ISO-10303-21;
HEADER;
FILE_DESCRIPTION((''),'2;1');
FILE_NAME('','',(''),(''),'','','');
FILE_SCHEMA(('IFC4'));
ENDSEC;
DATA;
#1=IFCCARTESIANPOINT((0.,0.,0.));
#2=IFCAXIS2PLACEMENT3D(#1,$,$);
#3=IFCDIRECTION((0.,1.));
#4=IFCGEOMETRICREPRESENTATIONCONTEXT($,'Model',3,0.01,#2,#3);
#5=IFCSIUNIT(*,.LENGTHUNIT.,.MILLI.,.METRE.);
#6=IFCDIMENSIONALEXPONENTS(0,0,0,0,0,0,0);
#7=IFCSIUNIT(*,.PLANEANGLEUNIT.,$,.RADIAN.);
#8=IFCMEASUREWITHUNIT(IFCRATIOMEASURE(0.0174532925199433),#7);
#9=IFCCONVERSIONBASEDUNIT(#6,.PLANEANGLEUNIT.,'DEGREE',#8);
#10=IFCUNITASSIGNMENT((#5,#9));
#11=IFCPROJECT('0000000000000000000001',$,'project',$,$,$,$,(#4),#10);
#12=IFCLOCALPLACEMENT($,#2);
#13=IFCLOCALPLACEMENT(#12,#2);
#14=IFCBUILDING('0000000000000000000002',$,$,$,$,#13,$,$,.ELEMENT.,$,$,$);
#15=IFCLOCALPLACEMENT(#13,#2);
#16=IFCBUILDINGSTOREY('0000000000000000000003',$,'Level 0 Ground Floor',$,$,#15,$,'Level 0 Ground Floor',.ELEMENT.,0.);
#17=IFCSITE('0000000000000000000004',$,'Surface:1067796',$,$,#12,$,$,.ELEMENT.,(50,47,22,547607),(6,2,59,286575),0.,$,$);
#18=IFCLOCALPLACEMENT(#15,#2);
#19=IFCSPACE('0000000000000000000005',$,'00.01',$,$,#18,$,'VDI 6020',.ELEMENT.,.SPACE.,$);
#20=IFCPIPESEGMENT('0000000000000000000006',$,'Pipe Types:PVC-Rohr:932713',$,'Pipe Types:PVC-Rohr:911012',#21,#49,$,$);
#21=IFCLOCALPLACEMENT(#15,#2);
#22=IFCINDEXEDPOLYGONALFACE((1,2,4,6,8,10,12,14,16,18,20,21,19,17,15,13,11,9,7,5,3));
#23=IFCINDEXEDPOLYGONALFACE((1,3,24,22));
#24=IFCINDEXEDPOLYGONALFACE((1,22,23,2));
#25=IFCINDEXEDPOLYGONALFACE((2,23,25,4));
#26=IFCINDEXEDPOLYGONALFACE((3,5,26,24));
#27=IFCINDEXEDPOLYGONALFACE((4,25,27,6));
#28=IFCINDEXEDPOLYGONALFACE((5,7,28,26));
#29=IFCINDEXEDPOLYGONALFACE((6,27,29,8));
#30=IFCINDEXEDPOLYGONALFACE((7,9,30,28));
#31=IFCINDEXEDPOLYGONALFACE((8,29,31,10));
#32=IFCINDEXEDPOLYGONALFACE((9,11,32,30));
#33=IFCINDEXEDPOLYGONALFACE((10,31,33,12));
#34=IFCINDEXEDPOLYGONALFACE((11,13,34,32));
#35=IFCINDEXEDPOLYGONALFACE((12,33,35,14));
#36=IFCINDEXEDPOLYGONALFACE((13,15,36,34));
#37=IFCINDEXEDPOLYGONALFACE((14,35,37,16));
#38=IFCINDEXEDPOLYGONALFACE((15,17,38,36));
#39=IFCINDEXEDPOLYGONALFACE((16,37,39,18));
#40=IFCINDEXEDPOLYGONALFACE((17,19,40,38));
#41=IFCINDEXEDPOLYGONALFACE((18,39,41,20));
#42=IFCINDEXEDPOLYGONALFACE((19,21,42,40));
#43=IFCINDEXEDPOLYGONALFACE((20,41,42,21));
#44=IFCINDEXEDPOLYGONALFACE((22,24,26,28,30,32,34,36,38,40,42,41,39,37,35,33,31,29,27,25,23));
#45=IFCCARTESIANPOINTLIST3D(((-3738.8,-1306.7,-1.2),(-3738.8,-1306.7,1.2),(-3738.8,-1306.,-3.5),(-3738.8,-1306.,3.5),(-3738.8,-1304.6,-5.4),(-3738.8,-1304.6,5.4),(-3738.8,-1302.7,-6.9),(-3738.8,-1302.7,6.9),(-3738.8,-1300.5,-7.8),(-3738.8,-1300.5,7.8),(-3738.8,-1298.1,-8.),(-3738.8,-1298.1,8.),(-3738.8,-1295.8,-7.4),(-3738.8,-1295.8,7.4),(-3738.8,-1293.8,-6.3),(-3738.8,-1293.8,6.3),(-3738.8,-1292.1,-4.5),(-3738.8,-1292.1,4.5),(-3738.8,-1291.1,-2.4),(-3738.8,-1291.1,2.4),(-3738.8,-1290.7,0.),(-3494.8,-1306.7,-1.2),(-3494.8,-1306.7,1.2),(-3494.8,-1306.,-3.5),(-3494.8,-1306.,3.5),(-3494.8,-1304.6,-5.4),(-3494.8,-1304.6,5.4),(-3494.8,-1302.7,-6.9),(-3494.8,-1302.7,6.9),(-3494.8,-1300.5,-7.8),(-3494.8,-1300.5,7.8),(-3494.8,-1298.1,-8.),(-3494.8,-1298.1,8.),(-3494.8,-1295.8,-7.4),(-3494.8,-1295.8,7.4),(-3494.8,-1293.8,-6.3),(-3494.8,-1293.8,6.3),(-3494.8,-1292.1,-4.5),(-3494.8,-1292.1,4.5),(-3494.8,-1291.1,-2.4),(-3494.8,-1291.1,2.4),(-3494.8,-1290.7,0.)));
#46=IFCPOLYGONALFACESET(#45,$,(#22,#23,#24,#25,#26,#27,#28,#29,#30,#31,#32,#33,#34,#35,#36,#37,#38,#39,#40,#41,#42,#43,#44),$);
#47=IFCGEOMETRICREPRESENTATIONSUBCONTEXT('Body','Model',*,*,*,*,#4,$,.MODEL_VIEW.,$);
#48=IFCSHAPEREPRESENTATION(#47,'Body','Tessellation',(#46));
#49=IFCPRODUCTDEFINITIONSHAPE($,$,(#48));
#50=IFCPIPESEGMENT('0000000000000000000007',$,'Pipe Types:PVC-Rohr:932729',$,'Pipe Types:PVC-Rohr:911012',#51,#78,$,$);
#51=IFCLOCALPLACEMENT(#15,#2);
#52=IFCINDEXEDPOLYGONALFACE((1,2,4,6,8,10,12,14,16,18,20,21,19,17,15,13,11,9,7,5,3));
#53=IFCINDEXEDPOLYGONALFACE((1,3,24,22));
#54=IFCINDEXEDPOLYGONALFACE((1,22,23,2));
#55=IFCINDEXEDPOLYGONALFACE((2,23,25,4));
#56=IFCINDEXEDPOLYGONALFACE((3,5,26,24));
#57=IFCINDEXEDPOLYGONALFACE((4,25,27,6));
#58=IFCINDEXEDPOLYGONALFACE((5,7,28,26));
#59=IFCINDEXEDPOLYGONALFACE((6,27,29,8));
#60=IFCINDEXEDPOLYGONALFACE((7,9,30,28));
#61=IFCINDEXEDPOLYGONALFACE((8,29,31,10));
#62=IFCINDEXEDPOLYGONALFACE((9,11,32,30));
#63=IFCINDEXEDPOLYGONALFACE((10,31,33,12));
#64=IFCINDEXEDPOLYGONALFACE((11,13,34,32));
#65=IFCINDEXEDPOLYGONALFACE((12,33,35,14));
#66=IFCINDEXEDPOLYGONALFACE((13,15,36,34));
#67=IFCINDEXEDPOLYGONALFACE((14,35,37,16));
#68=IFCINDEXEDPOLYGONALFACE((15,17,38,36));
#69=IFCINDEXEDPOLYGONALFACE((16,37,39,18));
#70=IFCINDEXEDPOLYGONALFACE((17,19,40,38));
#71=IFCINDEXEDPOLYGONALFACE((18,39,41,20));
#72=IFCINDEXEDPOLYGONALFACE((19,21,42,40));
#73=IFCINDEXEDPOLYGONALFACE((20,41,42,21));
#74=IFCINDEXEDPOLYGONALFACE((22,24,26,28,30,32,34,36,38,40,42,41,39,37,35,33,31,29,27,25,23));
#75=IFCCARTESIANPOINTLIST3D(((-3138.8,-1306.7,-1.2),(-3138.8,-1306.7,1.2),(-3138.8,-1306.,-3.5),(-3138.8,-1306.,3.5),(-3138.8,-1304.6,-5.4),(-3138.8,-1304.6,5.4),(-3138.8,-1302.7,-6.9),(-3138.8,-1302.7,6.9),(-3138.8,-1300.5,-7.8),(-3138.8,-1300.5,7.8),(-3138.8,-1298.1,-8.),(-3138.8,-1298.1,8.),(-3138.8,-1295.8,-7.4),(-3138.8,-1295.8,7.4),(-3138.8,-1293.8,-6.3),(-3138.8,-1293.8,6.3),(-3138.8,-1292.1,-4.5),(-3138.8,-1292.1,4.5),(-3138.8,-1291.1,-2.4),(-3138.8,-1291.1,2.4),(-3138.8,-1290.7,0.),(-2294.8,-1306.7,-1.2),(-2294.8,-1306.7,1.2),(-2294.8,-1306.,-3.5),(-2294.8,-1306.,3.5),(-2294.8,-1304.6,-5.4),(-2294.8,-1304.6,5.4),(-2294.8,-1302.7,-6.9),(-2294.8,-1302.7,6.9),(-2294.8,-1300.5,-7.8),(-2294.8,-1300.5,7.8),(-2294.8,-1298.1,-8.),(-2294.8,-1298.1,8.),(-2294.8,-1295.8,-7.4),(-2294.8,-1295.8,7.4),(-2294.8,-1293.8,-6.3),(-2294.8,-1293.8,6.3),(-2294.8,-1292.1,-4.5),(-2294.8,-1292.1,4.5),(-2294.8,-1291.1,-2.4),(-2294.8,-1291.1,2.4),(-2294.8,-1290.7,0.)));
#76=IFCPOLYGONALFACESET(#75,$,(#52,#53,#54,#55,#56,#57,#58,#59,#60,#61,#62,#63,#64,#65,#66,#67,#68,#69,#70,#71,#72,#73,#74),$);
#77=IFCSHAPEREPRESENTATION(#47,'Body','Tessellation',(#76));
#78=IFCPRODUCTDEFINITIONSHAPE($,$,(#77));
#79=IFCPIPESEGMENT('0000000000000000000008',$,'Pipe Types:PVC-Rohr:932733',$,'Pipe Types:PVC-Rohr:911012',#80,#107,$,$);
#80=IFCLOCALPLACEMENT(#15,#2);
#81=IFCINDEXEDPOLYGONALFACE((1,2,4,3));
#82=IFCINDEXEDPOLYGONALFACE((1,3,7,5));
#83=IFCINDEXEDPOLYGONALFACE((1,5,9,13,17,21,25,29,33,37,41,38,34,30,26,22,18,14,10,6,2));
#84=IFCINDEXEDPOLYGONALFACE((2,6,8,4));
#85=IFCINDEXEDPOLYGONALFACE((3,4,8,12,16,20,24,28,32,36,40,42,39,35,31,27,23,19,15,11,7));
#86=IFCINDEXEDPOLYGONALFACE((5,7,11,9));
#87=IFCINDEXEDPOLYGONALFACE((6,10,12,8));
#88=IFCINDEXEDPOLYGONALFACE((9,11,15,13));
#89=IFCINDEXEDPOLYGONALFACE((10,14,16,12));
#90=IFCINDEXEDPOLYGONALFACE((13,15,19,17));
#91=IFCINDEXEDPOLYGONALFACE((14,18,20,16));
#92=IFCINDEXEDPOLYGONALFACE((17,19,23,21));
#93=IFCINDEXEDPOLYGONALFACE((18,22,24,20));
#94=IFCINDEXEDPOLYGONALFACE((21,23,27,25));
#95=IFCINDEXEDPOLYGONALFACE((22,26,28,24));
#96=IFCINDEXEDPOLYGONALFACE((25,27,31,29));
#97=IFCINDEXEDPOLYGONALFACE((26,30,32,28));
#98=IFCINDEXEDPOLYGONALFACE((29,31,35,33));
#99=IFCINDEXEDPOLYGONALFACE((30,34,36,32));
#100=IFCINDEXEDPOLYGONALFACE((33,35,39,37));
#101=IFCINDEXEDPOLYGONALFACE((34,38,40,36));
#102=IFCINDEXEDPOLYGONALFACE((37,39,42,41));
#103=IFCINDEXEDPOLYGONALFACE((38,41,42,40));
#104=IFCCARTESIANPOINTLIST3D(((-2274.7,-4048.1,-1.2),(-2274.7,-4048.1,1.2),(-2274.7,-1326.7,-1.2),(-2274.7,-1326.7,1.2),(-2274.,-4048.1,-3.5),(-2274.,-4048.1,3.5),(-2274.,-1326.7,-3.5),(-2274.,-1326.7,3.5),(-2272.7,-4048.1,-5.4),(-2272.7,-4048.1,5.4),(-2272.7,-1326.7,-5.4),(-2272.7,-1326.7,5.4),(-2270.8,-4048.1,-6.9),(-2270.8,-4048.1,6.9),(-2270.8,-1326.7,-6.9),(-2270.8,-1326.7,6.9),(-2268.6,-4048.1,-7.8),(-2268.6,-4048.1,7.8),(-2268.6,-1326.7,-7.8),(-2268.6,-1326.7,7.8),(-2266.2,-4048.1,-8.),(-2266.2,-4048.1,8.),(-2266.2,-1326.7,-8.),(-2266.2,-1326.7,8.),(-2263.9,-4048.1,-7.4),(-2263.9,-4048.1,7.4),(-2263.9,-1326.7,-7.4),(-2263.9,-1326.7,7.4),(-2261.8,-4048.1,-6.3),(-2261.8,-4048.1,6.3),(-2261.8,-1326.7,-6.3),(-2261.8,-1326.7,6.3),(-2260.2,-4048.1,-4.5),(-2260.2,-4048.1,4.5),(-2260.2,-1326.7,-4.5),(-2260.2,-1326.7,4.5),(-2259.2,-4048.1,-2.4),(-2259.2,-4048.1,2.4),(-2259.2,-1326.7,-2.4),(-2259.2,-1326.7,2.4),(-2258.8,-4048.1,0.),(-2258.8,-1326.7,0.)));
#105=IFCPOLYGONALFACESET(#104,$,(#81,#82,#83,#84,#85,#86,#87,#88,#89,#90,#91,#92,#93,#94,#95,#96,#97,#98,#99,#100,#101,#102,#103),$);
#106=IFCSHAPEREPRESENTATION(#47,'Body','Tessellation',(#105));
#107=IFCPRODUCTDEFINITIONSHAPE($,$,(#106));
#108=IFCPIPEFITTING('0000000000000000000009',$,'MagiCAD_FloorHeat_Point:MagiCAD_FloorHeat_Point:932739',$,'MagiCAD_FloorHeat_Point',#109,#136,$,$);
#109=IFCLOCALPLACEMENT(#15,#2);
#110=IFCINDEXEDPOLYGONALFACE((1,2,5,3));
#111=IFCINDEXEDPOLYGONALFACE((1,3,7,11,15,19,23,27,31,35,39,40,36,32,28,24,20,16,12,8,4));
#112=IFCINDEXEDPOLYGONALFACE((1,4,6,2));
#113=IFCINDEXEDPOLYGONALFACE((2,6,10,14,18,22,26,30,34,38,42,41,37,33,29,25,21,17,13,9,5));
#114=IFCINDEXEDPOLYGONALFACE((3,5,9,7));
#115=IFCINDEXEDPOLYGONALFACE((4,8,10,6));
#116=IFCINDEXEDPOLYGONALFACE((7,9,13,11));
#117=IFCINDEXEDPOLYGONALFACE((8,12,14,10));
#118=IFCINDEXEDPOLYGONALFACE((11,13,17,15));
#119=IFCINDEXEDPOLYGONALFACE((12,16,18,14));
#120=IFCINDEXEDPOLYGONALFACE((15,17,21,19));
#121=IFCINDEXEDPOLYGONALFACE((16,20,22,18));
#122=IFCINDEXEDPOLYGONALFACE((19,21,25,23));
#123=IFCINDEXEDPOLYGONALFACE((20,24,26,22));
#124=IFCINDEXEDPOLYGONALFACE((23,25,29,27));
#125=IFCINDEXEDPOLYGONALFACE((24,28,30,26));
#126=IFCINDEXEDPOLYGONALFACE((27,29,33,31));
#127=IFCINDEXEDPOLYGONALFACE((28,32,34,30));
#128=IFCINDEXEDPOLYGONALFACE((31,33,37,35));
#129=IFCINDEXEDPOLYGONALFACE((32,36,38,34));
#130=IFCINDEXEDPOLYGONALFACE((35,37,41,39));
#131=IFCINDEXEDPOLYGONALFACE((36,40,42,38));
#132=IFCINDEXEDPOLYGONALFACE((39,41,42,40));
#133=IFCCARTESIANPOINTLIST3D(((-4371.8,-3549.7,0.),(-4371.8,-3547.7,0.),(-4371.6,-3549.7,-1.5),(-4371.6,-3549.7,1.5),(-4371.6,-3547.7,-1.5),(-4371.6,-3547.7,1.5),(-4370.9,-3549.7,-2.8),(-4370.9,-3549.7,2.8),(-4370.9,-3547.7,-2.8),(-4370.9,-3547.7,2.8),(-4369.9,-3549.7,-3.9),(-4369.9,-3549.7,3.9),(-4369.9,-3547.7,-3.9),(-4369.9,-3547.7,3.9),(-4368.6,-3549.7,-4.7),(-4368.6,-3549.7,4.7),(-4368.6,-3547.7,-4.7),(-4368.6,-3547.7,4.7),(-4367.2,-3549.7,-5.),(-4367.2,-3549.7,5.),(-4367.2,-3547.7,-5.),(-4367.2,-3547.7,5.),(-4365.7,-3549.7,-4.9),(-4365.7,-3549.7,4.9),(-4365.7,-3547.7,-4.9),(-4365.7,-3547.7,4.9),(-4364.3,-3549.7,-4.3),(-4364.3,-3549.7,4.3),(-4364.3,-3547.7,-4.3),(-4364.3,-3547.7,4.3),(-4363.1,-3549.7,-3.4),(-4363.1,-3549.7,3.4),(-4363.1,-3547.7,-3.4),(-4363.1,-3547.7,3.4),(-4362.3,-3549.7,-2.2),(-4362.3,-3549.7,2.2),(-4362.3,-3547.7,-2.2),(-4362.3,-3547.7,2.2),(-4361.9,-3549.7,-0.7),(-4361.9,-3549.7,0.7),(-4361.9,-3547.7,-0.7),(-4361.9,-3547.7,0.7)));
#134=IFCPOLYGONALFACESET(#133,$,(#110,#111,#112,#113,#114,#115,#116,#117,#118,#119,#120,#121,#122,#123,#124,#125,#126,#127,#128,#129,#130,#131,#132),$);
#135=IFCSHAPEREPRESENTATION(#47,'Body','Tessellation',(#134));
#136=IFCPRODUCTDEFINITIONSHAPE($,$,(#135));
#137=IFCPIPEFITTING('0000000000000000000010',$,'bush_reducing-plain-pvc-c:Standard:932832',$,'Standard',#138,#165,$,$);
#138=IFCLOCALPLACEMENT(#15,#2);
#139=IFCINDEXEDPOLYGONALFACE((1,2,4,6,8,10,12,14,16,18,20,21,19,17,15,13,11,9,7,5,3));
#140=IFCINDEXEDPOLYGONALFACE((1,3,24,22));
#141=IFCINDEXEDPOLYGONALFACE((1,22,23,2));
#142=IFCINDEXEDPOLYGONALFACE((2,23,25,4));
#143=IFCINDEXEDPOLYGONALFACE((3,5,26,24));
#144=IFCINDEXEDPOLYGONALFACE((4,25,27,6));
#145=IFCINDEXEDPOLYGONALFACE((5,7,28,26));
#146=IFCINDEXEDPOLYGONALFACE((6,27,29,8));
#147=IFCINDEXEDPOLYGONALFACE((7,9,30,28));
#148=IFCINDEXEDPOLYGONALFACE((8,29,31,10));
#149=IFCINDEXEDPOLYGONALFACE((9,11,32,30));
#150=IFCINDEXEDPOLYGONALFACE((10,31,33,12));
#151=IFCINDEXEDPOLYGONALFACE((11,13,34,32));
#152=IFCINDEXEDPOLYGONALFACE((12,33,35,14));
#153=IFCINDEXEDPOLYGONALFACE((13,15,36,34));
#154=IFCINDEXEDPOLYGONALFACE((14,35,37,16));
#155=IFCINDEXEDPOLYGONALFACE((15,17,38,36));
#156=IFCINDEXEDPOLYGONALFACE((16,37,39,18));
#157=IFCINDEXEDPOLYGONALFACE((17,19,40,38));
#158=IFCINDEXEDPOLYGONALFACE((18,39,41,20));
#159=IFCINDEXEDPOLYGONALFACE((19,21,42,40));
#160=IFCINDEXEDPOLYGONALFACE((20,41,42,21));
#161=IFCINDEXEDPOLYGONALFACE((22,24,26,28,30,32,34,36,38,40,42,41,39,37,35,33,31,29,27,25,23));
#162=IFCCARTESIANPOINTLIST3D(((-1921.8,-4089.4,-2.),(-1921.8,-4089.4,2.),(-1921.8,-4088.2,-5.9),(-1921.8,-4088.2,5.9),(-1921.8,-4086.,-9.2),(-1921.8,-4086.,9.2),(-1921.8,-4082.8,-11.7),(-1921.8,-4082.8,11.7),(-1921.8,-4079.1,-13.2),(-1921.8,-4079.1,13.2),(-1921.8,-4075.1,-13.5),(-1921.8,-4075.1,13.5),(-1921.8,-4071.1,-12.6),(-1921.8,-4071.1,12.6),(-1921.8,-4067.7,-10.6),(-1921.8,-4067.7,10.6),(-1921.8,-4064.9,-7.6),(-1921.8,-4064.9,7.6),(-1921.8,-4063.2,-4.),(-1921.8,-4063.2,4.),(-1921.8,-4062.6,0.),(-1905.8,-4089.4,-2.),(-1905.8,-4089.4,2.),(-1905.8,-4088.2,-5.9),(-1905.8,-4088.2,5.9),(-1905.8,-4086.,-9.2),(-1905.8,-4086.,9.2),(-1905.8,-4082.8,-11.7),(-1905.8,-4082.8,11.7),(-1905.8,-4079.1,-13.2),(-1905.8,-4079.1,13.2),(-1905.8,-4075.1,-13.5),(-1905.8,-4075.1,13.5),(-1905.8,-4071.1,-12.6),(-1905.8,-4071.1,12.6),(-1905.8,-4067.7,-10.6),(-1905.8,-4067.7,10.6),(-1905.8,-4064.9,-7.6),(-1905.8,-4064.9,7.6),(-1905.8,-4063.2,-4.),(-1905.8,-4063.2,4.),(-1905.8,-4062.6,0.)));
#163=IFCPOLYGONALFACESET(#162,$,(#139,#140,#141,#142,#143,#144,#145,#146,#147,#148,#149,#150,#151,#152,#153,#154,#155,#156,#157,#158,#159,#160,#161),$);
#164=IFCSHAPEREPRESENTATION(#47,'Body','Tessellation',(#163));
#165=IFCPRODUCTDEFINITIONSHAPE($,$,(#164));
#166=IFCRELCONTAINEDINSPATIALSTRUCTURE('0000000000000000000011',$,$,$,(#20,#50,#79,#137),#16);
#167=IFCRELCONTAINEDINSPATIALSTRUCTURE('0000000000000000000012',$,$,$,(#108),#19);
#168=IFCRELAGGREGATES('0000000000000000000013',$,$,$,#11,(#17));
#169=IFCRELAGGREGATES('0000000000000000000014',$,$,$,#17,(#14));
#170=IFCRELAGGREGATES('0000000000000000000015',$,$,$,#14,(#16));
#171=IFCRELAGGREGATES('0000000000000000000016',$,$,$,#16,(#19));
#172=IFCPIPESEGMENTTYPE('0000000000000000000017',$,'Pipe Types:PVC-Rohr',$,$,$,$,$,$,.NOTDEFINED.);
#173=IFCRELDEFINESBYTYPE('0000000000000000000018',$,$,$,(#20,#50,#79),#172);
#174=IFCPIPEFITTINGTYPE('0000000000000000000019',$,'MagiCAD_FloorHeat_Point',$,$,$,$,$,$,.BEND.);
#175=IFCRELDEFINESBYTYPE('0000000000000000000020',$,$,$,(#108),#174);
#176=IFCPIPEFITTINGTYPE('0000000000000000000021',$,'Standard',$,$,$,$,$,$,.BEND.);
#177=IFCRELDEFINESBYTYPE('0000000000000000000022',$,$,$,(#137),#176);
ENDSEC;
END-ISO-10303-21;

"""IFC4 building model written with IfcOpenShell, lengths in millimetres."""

from ifc_helpers import new_model, entity, si_unit, converted_unit, direction, frame, frame_2d, origin, place, context, subcontext, project, spatial, circle, extrude, source, transform, mapped, type_object, type_shapes, element, save


model = new_model("IFC4")

# Units and contexts
model_context = context("Model", 3, precision=0.01, world=origin(), true_north=direction((0.0, 1.0)))
body_context = subcontext(model_context, "Body", "Model", "MODEL_VIEW")
ifc_project = project(units=[si_unit("LENGTHUNIT", "METRE", prefix="MILLI"), converted_unit("PLANEANGLEUNIT", "DEGREE", entity("IfcRatioMeasure", 0.0174532925199433), si_unit("PLANEANGLEUNIT", "RADIAN"), dimensions=[0, 0, 0, 0, 0, 0, 0])], contexts=[model_context])

# Site, building, storey
site_placement = place(None, origin())
site = spatial("IfcSite", under=ifc_project, at=site_placement, Name="Surface:1067796", CompositionType="ELEMENT", RefLatitude=(50, 47, 22, 547607), RefLongitude=(6, 2, 59, 286575), RefElevation=0.0)
building_placement = place(site_placement, origin())
building = spatial("IfcBuilding", under=site, at=building_placement, CompositionType="ELEMENT")
storey_placement = place(building_placement, origin())
storey = spatial("IfcBuildingStorey", under=building, at=storey_placement, Name="Level 0 Ground Floor", LongName="Level 0 Ground Floor", CompositionType="ELEMENT", Elevation=0.0)

# Pipe segments
pipe_segment_type_1 = type_object("IfcPipeSegmentType", Name="Pipe Types:PVC-Rohr", PredefinedType="NOTDEFINED")
pipe_segment_1_placement = place(storey_placement, frame((-3738.8, -1308.3, -9.6)))
element("IfcPipeSegment", 1, at=pipe_segment_1_placement, inside=storey, type_object=pipe_segment_type_1, Name="Pipe Types:PVC-Rohr:932713", ObjectType="Pipe Types:PVC-Rohr:911012", context=body_context, shape_type="SweptSolid", body=[
    extrude(circle(Radius=8.0, at=frame_2d((0.0, 0.0), x_axis=(1.0, 0.0))), frame((0.0, 9.6, 9.6), z_axis=(1.0, 0.0, 0.0), x_axis=(0.0, 1.0, 0.0)), (0.0, 0.0, 1.0), 244.0),
])
pipe_segment_2_placement = place(storey_placement, frame((-3138.8, -1308.3, -9.6)))
element("IfcPipeSegment", 2, at=pipe_segment_2_placement, inside=storey, type_object=pipe_segment_type_1, Name="Pipe Types:PVC-Rohr:932729", ObjectType="Pipe Types:PVC-Rohr:911012", context=body_context, shape_type="SweptSolid", body=[
    extrude(circle(Radius=8.0, at=frame_2d((0.0, 0.0), x_axis=(1.0, 0.0))), frame((0.0, 9.6, 9.6), z_axis=(1.0, 0.0, 0.0), x_axis=(0.0, 1.0, 0.0)), (0.0, 0.0, 1.0), 844.0),
])
pipe_segment_3_placement = place(storey_placement, frame((-2276.4, -4048.1, -9.6)))
element("IfcPipeSegment", 3, at=pipe_segment_3_placement, inside=storey, type_object=pipe_segment_type_1, Name="Pipe Types:PVC-Rohr:932733", ObjectType="Pipe Types:PVC-Rohr:911012", context=body_context, shape_type="SweptSolid", body=[
    extrude(circle(Radius=8.0, at=frame_2d((0.0, 0.0), x_axis=(1.0, 0.0))), frame((9.6, 0.0, 9.6), z_axis=(0.0, 1.0, 0.0), x_axis=(1.0, 0.0, 0.0)), (0.0, 0.0, 1.0), 2721.3),
])

# Shared definitions
space_placement = place(storey_placement, origin())
space = spatial("IfcSpace", under=storey, at=space_placement, Name="00.01", LongName="VDI 6020", CompositionType="ELEMENT", PredefinedType="SPACE")

# Pipe fittings
pipe_fitting_type_1 = type_object("IfcPipeFittingType", Name="MagiCAD_FloorHeat_Point", PredefinedType="BEND")
shared_shape_1 = source(origin(), body_context, "Body", "SweptSolid", [
    extrude(circle(Radius=5.0, at=frame_2d((0.0, 0.0), x_axis=(1.0, 0.0))), frame((-1.0, 0.0, 0.0), z_axis=(1.0, 0.0, 0.0), x_axis=(0.0, 1.0, 0.0)), (0.0, 0.0, 1.0), 2.0),
])
type_shapes(pipe_fitting_type_1, [shared_shape_1])
pipe_fitting_1_placement = place(space_placement, frame((-4366.8, -3548.7, 0.0), z_axis=(0.0, 0.0, 1.0), x_axis=(0.0, 1.0, 0.0)))
element("IfcPipeFitting", 4, at=pipe_fitting_1_placement, inside=space, type_object=pipe_fitting_type_1, Name="MagiCAD_FloorHeat_Point:MagiCAD_FloorHeat_Point:932739", ObjectType="MagiCAD_FloorHeat_Point", context=body_context, shape_type="MappedRepresentation", body=[
    mapped(shared_shape_1, transform((0.0, 0.0, 0.0), scale=1.0)),
])
pipe_fitting_type_2 = type_object("IfcPipeFittingType", Name="Standard", PredefinedType="BEND")
shared_shape_2 = source(origin(), body_context, "Body", "SweptSolid", [
    extrude(circle(Radius=13.5, at=frame_2d((0.0, 0.0), x_axis=(1.0, 0.0))), frame((0.0, 0.0, 0.0), z_axis=(1.0, 0.0, 0.0), x_axis=(0.0, 1.0, 0.0)), (0.0, 0.0, 1.0), 16.0),
])
type_shapes(pipe_fitting_type_2, [shared_shape_2])
pipe_fitting_2_placement = place(storey_placement, frame((-1921.8, -4076.1, 0.0)))
element("IfcPipeFitting", 5, at=pipe_fitting_2_placement, inside=storey, type_object=pipe_fitting_type_2, Name="bush_reducing-plain-pvc-c:Standard:932832", ObjectType="Standard", context=body_context, shape_type="MappedRepresentation", body=[
    mapped(shared_shape_2, transform((0.0, 0.0, 0.0), scale=1.0)),
])

save(model, "model.ifc")
